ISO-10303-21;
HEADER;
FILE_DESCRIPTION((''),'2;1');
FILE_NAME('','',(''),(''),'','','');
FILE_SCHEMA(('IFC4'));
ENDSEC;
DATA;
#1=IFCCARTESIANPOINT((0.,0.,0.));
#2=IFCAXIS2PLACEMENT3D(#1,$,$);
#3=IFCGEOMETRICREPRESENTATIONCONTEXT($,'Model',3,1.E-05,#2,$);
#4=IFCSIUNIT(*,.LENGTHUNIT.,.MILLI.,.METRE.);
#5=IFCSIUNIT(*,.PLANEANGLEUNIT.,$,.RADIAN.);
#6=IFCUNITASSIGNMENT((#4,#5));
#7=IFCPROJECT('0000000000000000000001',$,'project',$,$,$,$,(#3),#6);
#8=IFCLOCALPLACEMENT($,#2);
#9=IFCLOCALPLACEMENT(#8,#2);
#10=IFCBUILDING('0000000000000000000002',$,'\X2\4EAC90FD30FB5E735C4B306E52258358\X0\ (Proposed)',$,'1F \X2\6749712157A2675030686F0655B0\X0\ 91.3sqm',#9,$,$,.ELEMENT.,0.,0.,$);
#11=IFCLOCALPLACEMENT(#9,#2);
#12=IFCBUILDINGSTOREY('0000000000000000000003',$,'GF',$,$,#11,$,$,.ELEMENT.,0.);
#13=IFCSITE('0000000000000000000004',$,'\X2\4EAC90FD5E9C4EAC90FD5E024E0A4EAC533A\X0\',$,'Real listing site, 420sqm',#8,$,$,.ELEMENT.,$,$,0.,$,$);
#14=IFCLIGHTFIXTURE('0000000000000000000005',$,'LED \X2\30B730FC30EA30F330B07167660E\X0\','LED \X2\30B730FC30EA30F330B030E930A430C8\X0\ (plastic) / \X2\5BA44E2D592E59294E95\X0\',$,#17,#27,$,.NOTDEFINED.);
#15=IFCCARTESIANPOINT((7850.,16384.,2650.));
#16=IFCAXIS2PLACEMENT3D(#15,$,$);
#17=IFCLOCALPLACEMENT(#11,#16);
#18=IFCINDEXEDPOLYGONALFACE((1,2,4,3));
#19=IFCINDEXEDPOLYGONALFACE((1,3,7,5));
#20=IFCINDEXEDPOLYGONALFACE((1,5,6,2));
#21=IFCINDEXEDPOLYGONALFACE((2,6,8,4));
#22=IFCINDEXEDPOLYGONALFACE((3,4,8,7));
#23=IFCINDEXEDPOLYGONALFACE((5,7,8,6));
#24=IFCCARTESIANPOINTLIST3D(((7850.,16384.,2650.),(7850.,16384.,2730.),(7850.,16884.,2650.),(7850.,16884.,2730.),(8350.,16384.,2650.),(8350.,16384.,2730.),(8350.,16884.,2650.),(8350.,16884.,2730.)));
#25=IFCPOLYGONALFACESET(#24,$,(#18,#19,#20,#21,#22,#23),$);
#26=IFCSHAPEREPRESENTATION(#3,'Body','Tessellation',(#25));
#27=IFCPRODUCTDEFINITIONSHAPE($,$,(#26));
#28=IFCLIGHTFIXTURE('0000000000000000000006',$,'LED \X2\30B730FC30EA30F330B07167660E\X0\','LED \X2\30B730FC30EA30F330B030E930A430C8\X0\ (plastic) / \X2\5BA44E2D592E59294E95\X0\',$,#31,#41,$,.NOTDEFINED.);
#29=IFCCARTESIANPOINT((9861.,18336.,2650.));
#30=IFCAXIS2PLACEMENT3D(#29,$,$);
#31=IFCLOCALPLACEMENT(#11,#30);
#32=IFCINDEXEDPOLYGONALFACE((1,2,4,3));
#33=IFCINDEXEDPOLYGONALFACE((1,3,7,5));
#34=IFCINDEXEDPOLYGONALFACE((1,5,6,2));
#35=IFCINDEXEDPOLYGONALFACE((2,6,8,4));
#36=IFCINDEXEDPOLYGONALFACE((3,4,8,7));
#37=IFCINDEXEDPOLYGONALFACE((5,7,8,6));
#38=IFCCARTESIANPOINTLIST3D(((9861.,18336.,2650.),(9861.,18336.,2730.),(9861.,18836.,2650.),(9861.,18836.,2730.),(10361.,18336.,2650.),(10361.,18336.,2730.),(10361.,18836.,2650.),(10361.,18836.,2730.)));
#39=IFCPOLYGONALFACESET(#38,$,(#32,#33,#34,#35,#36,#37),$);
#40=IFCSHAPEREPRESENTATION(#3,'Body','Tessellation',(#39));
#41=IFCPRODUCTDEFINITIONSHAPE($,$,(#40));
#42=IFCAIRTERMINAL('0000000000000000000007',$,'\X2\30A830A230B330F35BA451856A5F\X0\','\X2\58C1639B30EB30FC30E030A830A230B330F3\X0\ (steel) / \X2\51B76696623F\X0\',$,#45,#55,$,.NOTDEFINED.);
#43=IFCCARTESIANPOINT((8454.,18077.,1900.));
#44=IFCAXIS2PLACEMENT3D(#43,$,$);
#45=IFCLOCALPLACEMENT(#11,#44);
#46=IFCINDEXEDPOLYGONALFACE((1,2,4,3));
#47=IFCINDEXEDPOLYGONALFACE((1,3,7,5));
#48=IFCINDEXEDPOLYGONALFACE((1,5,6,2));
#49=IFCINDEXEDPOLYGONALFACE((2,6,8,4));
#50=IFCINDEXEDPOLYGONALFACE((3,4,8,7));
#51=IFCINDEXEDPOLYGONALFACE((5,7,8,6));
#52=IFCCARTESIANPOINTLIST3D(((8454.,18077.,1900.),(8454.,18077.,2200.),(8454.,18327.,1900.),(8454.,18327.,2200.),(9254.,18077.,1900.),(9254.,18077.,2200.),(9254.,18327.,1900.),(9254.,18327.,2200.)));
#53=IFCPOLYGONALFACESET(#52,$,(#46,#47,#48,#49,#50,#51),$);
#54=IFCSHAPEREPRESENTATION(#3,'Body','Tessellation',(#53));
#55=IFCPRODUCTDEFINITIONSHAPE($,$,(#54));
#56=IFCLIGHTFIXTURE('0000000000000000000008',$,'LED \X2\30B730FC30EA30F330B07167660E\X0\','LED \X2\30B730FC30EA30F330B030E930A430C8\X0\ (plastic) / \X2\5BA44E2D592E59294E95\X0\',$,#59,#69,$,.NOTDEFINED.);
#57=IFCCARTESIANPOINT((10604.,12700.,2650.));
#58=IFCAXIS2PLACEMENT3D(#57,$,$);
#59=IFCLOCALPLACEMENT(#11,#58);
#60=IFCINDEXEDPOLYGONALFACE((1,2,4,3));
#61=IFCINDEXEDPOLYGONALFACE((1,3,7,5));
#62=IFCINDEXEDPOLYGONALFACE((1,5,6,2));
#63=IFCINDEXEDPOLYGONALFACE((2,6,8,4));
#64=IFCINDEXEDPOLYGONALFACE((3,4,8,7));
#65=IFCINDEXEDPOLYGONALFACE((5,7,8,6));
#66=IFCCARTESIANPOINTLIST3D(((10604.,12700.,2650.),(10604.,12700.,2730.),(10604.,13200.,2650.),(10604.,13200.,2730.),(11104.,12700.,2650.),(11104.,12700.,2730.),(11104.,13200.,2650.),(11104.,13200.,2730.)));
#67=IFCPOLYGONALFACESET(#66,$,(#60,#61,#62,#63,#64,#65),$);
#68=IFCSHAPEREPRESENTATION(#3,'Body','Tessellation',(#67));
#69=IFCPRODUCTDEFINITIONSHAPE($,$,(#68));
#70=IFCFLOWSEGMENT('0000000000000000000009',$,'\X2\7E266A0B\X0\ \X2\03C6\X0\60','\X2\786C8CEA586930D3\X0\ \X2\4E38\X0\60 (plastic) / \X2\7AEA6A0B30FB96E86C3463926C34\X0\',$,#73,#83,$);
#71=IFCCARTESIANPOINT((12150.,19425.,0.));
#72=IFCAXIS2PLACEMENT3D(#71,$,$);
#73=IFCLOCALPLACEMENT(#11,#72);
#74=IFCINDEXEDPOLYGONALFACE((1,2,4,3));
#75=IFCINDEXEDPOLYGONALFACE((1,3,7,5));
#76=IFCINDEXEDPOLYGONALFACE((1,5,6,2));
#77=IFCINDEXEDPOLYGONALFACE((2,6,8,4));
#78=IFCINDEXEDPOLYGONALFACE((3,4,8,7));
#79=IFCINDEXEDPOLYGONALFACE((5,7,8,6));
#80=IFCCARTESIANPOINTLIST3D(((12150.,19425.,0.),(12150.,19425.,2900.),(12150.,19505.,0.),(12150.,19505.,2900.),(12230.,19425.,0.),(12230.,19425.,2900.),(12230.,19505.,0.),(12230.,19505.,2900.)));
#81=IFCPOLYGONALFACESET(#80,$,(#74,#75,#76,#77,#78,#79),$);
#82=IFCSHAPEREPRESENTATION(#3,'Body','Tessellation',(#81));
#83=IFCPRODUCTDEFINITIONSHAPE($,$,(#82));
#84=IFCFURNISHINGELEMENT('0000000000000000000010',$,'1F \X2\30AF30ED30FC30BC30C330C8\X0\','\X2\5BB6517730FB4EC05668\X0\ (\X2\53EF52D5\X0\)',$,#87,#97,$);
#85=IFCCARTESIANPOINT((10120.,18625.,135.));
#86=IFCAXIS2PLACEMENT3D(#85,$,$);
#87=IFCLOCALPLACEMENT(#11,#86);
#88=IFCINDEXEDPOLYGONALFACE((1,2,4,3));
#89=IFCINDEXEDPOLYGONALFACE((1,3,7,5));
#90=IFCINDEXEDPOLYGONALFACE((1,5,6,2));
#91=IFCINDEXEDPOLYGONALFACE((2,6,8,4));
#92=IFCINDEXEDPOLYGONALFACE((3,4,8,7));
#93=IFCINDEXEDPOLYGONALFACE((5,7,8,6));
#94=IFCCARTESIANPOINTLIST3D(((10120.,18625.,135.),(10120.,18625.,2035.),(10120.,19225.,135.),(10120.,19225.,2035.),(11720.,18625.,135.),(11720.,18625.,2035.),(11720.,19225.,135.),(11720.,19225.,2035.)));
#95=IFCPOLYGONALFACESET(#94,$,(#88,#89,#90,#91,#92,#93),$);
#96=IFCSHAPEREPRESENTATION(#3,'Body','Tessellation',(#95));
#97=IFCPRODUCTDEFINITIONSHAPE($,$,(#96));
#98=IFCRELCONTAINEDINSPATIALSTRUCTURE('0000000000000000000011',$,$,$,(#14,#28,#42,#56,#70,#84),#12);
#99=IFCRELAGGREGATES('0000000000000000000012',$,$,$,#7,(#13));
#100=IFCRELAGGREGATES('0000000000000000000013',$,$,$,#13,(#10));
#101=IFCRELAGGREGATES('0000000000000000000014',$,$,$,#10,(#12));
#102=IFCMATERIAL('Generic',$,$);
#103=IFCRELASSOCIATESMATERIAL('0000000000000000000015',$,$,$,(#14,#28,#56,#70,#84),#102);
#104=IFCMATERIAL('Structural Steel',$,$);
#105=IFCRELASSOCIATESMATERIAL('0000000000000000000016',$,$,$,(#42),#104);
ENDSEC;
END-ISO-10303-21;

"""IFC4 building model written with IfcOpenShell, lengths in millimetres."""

from ifc_helpers import new_model, si_unit, frame, frame_2d, origin, place, context, project, spatial, rectangle, extrude, material, element, save


model = new_model("IFC4")

# Units and contexts
model_context = context("Model", 3, precision=1e-05, world=origin())
ifc_project = project(units=[si_unit("LENGTHUNIT", "METRE", prefix="MILLI"), si_unit("PLANEANGLEUNIT", "RADIAN")], contexts=[model_context])

# Site, building, storey
site_placement = place(None, origin())
site = spatial("IfcSite", under=ifc_project, at=site_placement, Name="京都府京都市上京区", ObjectType="Real listing site, 420sqm", CompositionType="ELEMENT", RefElevation=0.0)
building_placement = place(site_placement, origin())
building = spatial("IfcBuilding", under=site, at=building_placement, Name="京都・平屋の別荘 (Proposed)", ObjectType="1F 杉無垢材と漆喰 91.3sqm", CompositionType="ELEMENT", ElevationOfRefHeight=0.0, ElevationOfTerrain=0.0)
storey_placement = place(building_placement, origin())
storey = spatial("IfcBuildingStorey", under=building, at=storey_placement, Name="GF", CompositionType="ELEMENT", Elevation=0.0)

# Shared definitions
ifc_material_1 = material(Name="Generic")

# Shared definitions
ifc_material_2 = material(Name="Structural Steel")

# Light fixtures
light_fixture_1_placement = place(storey_placement, frame((7850.0, 16384.0, 2650.0)))
element("IfcLightFixture", 1, at=light_fixture_1_placement, inside=storey, material=ifc_material_1, Name="LED シーリング照明", Description="LED シーリングライト (plastic) / 室中央天井", PredefinedType="NOTDEFINED", context=model_context, shape_type="SweptSolid", body=[
    extrude(rectangle(XDim=500.0, YDim=500.0, at=frame_2d((250.0, 250.0))), frame((7850.0, 16384.0, 2650.0)), (0.0, 0.0, 1.0), 80.0),
])
light_fixture_2_placement = place(storey_placement, frame((9861.0, 18336.0, 2650.0)))
element("IfcLightFixture", 2, at=light_fixture_2_placement, inside=storey, material=ifc_material_1, Name="LED シーリング照明", Description="LED シーリングライト (plastic) / 室中央天井", PredefinedType="NOTDEFINED", context=model_context, shape_type="SweptSolid", body=[
    extrude(rectangle(XDim=500.0, YDim=500.0, at=frame_2d((250.0, 250.0))), frame((9861.0, 18336.0, 2650.0)), (0.0, 0.0, 1.0), 80.0),
])

# Air terminal
air_terminal_placement = place(storey_placement, frame((8454.0, 18077.0, 1900.0)))
element("IfcAirTerminal", 3, at=air_terminal_placement, inside=storey, material=ifc_material_2, Name="エアコン室内機", Description="壁掛ルームエアコン (steel) / 冷暖房", PredefinedType="NOTDEFINED", context=model_context, shape_type="SweptSolid", body=[
    extrude(rectangle(XDim=800.0, YDim=250.0, at=frame_2d((400.0, 125.0))), frame((8454.0, 18077.0, 1900.0)), (0.0, 0.0, 1.0), 300.0),
])

# Light fixture
light_fixture_3_placement = place(storey_placement, frame((10604.0, 12700.0, 2650.0)))
element("IfcLightFixture", 4, at=light_fixture_3_placement, inside=storey, material=ifc_material_1, Name="LED シーリング照明", Description="LED シーリングライト (plastic) / 室中央天井", PredefinedType="NOTDEFINED", context=model_context, shape_type="SweptSolid", body=[
    extrude(rectangle(XDim=500.0, YDim=500.0, at=frame_2d((250.0, 250.0))), frame((10604.0, 12700.0, 2650.0)), (0.0, 0.0, 1.0), 80.0),
])

# Flow segment
flow_segment_placement = place(storey_placement, frame((12150.0, 19425.0, 0.0)))
element("IfcFlowSegment", 5, at=flow_segment_placement, inside=storey, material=ifc_material_1, Name="縦樋 φ60", Description="硬質塩ビ 丸60 (plastic) / 竪樋・雨水排水", context=model_context, shape_type="SweptSolid", body=[
    extrude(rectangle(XDim=80.0, YDim=80.0, at=frame_2d((40.0, 40.0))), frame((12150.0, 19425.0, 0.0)), (0.0, 0.0, 1.0), 2900.0),
])

# Furnishing element
furnishing_placement = place(storey_placement, frame((10120.0, 18625.0, 135.0)))
element("IfcFurnishingElement", 6, at=furnishing_placement, inside=storey, material=ifc_material_1, Name="1F クローゼット", Description="家具・什器 (可動)", context=model_context, shape_type="SweptSolid", body=[
    extrude(rectangle(XDim=1600.0, YDim=600.0, at=frame_2d((800.0, 300.0))), frame((10120.0, 18625.0, 135.0)), (0.0, 0.0, 1.0), 1900.0),
])

save(model, "model.ifc")
